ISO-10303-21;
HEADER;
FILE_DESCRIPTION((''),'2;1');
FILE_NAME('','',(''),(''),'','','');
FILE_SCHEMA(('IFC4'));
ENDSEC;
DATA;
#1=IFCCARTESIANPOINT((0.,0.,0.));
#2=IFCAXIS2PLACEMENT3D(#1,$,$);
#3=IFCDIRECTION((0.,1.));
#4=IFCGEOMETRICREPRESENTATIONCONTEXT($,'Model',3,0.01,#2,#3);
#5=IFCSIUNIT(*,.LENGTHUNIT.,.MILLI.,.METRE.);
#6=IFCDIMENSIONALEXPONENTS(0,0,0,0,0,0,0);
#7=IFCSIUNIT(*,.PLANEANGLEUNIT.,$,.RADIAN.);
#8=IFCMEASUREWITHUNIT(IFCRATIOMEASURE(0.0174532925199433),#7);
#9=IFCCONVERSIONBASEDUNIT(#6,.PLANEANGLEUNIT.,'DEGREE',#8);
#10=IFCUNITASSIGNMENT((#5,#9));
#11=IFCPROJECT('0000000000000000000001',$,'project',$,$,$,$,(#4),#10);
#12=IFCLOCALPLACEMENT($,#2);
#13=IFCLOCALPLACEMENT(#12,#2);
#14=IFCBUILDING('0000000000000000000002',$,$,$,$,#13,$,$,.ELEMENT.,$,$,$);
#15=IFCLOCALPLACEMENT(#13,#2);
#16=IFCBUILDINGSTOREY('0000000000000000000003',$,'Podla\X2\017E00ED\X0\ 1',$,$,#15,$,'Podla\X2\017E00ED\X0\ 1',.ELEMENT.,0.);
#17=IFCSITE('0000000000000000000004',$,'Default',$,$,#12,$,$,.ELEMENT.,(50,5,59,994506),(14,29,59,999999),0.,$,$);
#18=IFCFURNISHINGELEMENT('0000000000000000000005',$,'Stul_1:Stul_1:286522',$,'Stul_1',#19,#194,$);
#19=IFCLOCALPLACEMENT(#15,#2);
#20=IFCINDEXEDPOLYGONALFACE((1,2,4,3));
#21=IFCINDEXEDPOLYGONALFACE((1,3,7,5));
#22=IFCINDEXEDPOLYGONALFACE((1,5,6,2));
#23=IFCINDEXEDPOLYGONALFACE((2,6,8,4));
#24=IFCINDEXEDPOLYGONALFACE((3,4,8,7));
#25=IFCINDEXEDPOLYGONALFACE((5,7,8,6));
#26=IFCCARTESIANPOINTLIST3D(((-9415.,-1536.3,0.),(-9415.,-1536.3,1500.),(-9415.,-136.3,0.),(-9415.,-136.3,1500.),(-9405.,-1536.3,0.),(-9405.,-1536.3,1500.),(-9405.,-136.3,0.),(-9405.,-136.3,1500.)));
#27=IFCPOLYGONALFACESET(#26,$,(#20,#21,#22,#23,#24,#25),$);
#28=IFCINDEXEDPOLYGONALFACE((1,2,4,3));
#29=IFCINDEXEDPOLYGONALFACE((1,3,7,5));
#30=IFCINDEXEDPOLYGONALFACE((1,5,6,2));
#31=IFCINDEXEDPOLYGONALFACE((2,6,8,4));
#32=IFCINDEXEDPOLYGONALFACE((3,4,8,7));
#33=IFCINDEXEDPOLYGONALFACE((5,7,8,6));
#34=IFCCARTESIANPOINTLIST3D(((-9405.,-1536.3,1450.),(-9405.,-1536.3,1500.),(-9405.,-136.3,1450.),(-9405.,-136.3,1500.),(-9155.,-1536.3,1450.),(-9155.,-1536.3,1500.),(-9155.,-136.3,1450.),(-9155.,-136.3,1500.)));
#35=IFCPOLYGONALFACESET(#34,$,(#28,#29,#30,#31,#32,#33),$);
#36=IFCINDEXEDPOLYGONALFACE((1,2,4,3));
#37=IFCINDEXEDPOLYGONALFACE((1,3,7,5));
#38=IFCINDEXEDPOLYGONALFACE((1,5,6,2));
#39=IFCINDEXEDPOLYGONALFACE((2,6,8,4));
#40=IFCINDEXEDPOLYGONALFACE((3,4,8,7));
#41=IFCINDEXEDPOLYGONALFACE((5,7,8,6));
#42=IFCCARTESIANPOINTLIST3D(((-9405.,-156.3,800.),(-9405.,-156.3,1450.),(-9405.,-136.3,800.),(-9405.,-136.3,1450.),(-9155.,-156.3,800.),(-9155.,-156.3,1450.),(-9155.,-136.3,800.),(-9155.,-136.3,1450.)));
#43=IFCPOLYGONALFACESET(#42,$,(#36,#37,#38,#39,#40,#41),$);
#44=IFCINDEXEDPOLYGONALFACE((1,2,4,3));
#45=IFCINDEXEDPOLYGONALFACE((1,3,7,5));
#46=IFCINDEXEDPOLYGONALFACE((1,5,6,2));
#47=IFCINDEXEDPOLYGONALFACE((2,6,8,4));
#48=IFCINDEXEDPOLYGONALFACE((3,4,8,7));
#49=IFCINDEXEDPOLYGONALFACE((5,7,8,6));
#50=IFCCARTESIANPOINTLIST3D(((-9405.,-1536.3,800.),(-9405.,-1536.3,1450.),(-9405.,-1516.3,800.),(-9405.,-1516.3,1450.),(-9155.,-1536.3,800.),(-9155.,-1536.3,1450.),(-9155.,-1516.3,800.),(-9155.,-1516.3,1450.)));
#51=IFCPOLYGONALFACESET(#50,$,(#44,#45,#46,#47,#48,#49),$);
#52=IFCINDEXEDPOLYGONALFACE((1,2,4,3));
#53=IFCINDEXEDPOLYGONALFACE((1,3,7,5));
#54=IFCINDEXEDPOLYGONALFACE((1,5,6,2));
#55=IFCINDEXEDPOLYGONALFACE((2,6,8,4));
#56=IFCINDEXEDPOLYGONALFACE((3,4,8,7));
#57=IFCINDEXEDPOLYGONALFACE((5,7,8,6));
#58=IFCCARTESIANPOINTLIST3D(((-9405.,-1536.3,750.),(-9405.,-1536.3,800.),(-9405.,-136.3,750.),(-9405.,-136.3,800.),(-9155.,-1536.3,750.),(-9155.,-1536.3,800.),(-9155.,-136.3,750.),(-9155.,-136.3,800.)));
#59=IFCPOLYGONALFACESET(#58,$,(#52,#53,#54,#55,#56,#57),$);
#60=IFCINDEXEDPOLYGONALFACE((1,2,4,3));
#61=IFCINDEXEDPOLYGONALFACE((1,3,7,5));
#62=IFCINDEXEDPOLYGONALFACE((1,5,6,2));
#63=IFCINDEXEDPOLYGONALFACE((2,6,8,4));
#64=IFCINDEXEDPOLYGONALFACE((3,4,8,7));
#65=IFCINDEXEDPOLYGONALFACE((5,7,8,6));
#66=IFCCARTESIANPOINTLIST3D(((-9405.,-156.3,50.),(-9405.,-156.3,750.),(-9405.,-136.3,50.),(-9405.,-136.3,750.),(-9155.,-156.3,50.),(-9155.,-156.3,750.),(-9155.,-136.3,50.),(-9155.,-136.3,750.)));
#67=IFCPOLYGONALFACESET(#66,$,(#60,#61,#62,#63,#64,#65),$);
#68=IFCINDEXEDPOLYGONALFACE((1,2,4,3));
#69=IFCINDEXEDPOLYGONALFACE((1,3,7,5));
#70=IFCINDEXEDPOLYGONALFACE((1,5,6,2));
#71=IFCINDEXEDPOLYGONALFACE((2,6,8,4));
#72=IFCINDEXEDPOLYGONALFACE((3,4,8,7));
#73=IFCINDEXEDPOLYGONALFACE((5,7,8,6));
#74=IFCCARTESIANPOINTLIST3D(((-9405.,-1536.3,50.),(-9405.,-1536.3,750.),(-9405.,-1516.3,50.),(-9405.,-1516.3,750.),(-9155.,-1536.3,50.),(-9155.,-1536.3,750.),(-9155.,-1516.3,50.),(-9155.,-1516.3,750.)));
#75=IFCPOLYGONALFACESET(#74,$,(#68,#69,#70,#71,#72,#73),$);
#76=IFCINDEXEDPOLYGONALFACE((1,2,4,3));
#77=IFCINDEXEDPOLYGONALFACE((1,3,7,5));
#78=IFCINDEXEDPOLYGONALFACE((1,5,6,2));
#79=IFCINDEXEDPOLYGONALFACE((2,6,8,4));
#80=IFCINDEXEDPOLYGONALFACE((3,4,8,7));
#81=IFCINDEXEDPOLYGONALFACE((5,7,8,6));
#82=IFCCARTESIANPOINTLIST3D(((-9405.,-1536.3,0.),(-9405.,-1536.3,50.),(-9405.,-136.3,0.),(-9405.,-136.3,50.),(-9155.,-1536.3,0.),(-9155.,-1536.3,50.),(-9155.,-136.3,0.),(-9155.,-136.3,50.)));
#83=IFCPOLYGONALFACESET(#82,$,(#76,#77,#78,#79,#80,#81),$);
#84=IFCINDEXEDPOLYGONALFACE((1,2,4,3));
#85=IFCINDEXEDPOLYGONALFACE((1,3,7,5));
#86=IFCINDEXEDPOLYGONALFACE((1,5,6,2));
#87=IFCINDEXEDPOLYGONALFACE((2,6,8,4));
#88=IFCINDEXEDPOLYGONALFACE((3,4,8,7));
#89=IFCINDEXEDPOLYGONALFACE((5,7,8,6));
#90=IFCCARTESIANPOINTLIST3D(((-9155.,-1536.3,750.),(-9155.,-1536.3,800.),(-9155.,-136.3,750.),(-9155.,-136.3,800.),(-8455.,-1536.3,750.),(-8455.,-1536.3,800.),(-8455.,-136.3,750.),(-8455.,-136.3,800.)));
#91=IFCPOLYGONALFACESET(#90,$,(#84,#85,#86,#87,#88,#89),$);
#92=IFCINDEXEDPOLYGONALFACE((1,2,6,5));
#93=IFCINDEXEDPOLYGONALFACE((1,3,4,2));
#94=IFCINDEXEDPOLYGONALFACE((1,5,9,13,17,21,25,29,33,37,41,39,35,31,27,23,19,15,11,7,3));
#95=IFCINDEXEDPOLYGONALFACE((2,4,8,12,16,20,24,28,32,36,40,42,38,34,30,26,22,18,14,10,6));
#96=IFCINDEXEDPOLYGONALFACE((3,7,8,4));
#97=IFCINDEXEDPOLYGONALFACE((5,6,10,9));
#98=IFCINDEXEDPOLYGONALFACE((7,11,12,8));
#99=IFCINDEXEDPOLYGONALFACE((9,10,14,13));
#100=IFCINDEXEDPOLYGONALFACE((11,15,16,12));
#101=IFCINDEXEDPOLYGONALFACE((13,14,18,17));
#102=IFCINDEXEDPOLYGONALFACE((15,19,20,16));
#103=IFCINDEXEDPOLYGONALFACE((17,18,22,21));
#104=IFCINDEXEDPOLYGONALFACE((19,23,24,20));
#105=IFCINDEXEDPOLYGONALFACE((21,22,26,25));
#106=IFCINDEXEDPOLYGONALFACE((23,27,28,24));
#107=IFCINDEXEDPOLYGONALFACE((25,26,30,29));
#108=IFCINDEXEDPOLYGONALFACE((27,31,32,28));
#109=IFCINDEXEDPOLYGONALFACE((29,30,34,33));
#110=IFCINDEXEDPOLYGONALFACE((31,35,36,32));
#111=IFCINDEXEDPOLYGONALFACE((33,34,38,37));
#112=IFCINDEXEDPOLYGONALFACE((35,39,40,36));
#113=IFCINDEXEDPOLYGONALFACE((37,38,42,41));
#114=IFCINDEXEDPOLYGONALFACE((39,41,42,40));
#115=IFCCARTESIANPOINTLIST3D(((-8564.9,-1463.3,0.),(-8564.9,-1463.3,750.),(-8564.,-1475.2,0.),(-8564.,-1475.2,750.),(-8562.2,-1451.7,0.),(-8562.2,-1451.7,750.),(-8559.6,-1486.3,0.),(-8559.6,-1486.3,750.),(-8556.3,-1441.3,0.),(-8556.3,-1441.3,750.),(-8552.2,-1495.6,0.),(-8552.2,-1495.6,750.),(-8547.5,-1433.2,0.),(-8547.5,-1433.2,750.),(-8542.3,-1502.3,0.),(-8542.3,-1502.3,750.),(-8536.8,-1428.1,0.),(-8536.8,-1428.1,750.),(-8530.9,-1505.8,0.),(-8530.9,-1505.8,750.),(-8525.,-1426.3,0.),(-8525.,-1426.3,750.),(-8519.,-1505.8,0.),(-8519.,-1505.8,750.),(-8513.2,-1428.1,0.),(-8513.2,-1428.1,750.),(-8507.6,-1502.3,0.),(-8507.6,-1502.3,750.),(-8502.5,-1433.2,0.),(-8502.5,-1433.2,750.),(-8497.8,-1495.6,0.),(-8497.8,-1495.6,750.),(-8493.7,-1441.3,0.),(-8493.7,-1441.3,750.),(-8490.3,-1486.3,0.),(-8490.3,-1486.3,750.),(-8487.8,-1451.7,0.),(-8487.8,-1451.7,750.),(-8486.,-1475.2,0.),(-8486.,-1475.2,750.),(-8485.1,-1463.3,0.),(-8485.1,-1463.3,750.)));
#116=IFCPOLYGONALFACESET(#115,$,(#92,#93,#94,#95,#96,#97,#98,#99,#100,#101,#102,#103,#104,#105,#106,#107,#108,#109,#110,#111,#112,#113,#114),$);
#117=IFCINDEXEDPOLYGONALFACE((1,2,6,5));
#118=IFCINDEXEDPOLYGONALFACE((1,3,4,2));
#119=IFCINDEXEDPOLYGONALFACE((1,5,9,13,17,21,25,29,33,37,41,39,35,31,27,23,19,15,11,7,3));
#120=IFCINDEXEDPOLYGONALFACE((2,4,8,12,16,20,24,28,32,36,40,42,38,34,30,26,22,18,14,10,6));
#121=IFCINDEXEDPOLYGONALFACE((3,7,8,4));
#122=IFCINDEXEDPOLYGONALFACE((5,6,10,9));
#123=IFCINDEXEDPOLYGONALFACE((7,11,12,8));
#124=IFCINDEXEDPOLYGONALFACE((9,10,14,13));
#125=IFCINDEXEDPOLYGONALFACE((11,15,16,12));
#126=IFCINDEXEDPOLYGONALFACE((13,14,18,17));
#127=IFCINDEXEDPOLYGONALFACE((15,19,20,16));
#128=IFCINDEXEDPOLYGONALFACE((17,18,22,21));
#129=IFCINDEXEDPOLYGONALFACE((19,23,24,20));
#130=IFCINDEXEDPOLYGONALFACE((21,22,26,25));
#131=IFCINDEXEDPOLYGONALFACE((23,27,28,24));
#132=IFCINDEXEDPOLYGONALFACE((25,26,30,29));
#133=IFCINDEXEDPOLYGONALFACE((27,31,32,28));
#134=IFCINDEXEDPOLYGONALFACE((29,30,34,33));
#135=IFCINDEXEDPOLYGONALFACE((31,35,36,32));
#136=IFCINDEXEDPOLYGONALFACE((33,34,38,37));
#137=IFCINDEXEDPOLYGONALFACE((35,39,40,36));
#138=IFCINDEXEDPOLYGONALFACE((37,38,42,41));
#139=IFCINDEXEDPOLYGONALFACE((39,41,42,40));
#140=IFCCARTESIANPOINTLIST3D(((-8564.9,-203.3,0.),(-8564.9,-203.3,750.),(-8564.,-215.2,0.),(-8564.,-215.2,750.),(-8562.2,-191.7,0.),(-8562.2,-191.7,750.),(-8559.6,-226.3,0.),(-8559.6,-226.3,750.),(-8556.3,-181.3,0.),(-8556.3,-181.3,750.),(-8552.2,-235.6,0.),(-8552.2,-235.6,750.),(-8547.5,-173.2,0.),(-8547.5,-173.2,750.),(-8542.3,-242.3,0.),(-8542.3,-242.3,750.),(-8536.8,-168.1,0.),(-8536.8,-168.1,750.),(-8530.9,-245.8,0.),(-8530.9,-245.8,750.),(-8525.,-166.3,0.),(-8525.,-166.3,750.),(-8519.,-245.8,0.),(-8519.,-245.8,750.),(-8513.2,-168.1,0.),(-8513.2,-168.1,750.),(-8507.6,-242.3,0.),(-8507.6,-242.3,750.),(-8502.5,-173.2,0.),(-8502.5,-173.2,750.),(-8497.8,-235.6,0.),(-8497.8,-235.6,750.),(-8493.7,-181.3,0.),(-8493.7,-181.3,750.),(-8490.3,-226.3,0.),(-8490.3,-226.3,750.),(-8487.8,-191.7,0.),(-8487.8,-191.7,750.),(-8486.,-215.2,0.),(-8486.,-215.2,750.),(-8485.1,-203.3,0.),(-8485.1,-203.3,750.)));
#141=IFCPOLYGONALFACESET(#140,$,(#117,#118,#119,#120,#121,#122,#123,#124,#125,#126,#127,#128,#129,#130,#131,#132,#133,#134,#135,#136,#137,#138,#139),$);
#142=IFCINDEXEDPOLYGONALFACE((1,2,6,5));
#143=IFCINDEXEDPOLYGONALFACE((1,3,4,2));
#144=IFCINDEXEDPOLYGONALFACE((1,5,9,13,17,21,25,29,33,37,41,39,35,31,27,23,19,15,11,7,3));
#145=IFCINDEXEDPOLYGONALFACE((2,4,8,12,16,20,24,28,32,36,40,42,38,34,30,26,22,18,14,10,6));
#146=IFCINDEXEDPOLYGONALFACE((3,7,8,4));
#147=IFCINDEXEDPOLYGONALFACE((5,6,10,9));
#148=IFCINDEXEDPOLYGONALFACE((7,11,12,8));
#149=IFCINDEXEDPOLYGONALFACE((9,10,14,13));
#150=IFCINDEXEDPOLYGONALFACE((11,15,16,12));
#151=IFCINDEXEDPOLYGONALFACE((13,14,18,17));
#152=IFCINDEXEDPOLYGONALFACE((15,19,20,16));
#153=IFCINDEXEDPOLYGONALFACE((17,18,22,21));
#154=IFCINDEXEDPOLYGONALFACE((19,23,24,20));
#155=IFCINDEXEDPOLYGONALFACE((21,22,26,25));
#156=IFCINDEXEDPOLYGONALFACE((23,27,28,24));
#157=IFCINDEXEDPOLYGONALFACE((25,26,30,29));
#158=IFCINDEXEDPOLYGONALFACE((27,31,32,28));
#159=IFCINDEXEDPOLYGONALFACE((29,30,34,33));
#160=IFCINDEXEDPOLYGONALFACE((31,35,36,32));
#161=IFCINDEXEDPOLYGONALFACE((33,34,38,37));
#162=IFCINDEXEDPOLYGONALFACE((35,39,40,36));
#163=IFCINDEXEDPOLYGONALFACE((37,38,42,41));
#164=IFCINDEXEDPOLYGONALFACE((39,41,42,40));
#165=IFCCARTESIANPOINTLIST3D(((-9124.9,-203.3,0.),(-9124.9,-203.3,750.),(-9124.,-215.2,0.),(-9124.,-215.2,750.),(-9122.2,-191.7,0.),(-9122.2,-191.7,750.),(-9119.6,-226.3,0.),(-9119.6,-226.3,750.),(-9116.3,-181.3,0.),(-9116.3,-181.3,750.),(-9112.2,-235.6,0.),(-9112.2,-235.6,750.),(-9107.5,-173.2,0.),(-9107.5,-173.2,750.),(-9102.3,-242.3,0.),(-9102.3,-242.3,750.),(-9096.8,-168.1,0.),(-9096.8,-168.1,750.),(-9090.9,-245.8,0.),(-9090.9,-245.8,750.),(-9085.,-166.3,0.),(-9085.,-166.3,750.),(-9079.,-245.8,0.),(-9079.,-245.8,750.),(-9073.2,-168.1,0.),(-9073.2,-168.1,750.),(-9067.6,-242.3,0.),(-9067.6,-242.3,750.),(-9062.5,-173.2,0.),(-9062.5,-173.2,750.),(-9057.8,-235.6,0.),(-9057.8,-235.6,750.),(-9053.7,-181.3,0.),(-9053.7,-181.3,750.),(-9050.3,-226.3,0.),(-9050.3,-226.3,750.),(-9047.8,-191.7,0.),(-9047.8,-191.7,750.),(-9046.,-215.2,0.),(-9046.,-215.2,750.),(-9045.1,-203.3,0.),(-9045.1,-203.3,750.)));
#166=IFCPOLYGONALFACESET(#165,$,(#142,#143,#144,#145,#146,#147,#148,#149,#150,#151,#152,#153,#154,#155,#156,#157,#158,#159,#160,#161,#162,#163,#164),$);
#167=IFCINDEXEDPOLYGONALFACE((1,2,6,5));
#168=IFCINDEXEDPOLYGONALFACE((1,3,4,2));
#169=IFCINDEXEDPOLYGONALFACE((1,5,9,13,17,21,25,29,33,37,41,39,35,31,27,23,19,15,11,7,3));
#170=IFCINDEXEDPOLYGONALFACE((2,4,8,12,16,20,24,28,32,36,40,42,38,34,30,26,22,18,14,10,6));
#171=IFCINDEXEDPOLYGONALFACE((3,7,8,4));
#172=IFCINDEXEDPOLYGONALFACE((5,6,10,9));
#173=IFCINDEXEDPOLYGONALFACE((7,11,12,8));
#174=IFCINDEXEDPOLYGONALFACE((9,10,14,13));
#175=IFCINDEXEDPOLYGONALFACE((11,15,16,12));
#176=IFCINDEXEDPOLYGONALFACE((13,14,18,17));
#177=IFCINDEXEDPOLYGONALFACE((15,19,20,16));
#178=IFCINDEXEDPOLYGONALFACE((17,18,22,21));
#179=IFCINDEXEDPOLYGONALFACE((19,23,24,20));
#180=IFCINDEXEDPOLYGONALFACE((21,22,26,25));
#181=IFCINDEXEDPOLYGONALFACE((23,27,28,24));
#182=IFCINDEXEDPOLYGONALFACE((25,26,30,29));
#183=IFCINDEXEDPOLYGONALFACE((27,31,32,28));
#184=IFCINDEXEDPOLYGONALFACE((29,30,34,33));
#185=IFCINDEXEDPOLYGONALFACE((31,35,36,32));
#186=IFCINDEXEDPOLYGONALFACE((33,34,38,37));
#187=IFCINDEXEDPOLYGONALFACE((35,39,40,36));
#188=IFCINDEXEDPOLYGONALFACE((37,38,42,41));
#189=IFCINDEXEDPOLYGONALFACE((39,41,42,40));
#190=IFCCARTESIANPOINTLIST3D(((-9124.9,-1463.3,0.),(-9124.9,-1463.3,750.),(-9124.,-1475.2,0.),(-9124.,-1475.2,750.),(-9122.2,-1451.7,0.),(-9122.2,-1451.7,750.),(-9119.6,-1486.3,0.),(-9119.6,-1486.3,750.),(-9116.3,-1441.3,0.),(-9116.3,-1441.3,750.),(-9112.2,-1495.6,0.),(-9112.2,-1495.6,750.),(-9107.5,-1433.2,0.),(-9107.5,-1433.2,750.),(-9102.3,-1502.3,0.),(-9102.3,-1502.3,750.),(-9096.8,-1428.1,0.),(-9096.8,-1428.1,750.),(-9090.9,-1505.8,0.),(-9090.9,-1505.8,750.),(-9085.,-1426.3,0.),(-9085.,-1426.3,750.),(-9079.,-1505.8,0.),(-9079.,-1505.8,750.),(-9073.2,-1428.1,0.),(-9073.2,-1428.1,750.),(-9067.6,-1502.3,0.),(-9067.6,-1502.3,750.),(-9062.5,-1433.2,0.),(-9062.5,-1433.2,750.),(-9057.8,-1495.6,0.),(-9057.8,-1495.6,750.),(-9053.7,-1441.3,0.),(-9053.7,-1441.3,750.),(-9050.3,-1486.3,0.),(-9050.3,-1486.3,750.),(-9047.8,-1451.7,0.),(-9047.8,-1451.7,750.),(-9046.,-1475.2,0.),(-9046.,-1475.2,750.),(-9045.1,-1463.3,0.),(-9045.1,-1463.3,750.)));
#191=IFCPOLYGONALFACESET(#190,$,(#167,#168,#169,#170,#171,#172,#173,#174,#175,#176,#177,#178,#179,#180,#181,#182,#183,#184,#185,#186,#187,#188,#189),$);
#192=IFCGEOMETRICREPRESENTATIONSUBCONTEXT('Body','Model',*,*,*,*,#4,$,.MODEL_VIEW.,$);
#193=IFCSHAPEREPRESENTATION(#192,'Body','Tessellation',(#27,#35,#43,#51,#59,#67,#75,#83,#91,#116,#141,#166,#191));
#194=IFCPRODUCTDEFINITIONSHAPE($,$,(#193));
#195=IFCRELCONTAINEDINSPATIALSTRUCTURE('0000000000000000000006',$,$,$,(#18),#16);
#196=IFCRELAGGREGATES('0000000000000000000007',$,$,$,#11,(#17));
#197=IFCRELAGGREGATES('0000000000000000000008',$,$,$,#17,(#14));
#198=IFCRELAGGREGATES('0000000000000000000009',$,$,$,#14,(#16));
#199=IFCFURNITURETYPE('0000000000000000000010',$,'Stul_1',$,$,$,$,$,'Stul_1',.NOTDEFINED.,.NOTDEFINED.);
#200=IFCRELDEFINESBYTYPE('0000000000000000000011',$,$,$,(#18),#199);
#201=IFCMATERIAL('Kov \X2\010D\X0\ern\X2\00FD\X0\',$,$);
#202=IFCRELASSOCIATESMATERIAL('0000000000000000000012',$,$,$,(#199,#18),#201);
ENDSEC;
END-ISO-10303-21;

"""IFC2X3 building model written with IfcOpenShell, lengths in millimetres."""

from ifc_helpers import new_model, entity, si_unit, converted_unit, direction, frame, frame_2d, origin, origin_2d_with_axis, place, context, subcontext, project, spatial, rectangle, circle, extrude, source, transform, mapped, material, type_object, type_shapes, element, save


model = new_model("IFC2X3")

# Units and contexts
model_context = context("Model", 3, precision=0.01, world=origin(), true_north=direction((0.0, 1.0)))
body_context = subcontext(model_context, "Body", "Model", "MODEL_VIEW")
ifc_project = project(units=[si_unit("LENGTHUNIT", "METRE", prefix="MILLI"), converted_unit("PLANEANGLEUNIT", "DEGREE", entity("IfcRatioMeasure", 0.0174532925199433), si_unit("PLANEANGLEUNIT", "RADIAN"), dimensions=[0, 0, 0, 0, 0, 0, 0])], contexts=[model_context])

# Site, building, storey
site_placement = place(None, origin())
site = spatial("IfcSite", under=ifc_project, at=site_placement, Name="Default", CompositionType="ELEMENT", RefLatitude=(50, 5, 59, 994506), RefLongitude=(14, 29, 59, 999999), RefElevation=0.0)
building_placement = place(site_placement, origin())
building = spatial("IfcBuilding", under=site, at=building_placement, CompositionType="ELEMENT")
storey_placement = place(building_placement, origin())
storey = spatial("IfcBuildingStorey", under=building, at=storey_placement, Name="Podlaží 1", LongName="Podlaží 1", CompositionType="ELEMENT", Elevation=0.0)

# Furnishing element
ifc_material_1 = material(Name="Kov černý")
furniture_type = type_object("IfcFurnitureType", Name="Stul_1", ElementType="Stul_1", material=ifc_material_1)
shared_shape_1 = source(origin(), body_context, "Body", "SweptSolid", [
    extrude(rectangle(XDim=1400.0, YDim=10.0, at=origin_2d_with_axis()), frame((0.0, 605.0, 0.0), z_axis=(0.0, 0.0, 1.0), x_axis=(-1.0, 0.0, 0.0)), (0.0, 0.0, 1.0), 1500.0),
    extrude(rectangle(XDim=1400.0, YDim=250.0, at=frame_2d((0.0, 0.0), x_axis=(1.0, 0.0))), frame((0.0, 475.0, 1450.0), z_axis=(0.0, 0.0, 1.0), x_axis=(-1.0, 0.0, 0.0)), (0.0, 0.0, 1.0), 50.0),
    extrude(rectangle(XDim=20.0, YDim=250.0, at=origin_2d_with_axis()), frame((690.0, 475.0, 800.0), z_axis=(0.0, 0.0, 1.0), x_axis=(-1.0, 0.0, 0.0)), (0.0, 0.0, 1.0), 650.0),
    extrude(rectangle(XDim=20.0, YDim=250.0, at=frame_2d((0.0, 0.0), x_axis=(1.0, 0.0))), frame((-690.0, 475.0, 800.0), z_axis=(0.0, 0.0, 1.0), x_axis=(-1.0, 0.0, 0.0)), (0.0, 0.0, 1.0), 650.0),
    extrude(rectangle(XDim=1400.0, YDim=250.0, at=origin_2d_with_axis()), frame((0.0, 475.0, 750.0), z_axis=(0.0, 0.0, 1.0), x_axis=(-1.0, 0.0, 0.0)), (0.0, 0.0, 1.0), 50.0),
    extrude(rectangle(XDim=20.0, YDim=250.0, at=origin_2d_with_axis()), frame((690.0, 475.0, 50.0), z_axis=(0.0, 0.0, 1.0), x_axis=(-1.0, 0.0, 0.0)), (0.0, 0.0, 1.0), 700.0),
    extrude(rectangle(XDim=20.0, YDim=250.0, at=frame_2d((0.0, 0.0), x_axis=(1.0, 0.0))), frame((-690.0, 475.0, 50.0), z_axis=(0.0, 0.0, 1.0), x_axis=(-1.0, 0.0, 0.0)), (0.0, 0.0, 1.0), 700.0),
    extrude(rectangle(XDim=1400.0, YDim=250.0, at=origin_2d_with_axis()), frame((0.0, 475.0, 0.0), z_axis=(0.0, 0.0, 1.0), x_axis=(-1.0, 0.0, 0.0)), (0.0, 0.0, 1.0), 50.0),
    extrude(rectangle(XDim=1400.0, YDim=700.0, at=origin_2d_with_axis()), frame((0.0, 0.0, 750.0), z_axis=(0.0, 0.0, 1.0), x_axis=(-1.0, 0.0, 0.0)), (0.0, 0.0, 1.0), 50.0),
    extrude(circle(Radius=40.0, at=frame_2d((0.0, 0.0), x_axis=(1.0, 0.0))), frame((-630.0, -280.0, 0.0)), (0.0, 0.0, 1.0), 750.0),
    extrude(circle(Radius=40.0, at=frame_2d((0.0, 0.0), x_axis=(1.0, 0.0))), frame((630.0, -280.0, 0.0)), (0.0, 0.0, 1.0), 750.0),
    extrude(circle(Radius=40.0, at=frame_2d((0.0, 0.0), x_axis=(1.0, 0.0))), frame((630.0, 280.0, 0.0)), (0.0, 0.0, 1.0), 750.0),
    extrude(circle(Radius=40.0, at=frame_2d((0.0, 0.0), x_axis=(1.0, 0.0))), frame((-630.0, 280.0, 0.0)), (0.0, 0.0, 1.0), 750.0),
])
type_shapes(furniture_type, [shared_shape_1])
for number, where, z_axis, x_axis, name in (
    (1, (-8805.0, -836.3, 0.0), (0.0, 0.0, 1.0), (0.0, 1.0, 0.0), "Stul_1:Stul_1:286522"),
):
    element("IfcFurnishingElement", number, at=place(storey_placement, frame(where, z_axis=z_axis, x_axis=x_axis)), inside=storey, type_object=furniture_type, material=ifc_material_1, Name=name, ObjectType="Stul_1", context=body_context, shape_type="MappedRepresentation", body=[
        mapped(shared_shape_1, transform((0.0, 0.0, 0.0), scale=1.0)),
    ])

save(model, "model.ifc")
